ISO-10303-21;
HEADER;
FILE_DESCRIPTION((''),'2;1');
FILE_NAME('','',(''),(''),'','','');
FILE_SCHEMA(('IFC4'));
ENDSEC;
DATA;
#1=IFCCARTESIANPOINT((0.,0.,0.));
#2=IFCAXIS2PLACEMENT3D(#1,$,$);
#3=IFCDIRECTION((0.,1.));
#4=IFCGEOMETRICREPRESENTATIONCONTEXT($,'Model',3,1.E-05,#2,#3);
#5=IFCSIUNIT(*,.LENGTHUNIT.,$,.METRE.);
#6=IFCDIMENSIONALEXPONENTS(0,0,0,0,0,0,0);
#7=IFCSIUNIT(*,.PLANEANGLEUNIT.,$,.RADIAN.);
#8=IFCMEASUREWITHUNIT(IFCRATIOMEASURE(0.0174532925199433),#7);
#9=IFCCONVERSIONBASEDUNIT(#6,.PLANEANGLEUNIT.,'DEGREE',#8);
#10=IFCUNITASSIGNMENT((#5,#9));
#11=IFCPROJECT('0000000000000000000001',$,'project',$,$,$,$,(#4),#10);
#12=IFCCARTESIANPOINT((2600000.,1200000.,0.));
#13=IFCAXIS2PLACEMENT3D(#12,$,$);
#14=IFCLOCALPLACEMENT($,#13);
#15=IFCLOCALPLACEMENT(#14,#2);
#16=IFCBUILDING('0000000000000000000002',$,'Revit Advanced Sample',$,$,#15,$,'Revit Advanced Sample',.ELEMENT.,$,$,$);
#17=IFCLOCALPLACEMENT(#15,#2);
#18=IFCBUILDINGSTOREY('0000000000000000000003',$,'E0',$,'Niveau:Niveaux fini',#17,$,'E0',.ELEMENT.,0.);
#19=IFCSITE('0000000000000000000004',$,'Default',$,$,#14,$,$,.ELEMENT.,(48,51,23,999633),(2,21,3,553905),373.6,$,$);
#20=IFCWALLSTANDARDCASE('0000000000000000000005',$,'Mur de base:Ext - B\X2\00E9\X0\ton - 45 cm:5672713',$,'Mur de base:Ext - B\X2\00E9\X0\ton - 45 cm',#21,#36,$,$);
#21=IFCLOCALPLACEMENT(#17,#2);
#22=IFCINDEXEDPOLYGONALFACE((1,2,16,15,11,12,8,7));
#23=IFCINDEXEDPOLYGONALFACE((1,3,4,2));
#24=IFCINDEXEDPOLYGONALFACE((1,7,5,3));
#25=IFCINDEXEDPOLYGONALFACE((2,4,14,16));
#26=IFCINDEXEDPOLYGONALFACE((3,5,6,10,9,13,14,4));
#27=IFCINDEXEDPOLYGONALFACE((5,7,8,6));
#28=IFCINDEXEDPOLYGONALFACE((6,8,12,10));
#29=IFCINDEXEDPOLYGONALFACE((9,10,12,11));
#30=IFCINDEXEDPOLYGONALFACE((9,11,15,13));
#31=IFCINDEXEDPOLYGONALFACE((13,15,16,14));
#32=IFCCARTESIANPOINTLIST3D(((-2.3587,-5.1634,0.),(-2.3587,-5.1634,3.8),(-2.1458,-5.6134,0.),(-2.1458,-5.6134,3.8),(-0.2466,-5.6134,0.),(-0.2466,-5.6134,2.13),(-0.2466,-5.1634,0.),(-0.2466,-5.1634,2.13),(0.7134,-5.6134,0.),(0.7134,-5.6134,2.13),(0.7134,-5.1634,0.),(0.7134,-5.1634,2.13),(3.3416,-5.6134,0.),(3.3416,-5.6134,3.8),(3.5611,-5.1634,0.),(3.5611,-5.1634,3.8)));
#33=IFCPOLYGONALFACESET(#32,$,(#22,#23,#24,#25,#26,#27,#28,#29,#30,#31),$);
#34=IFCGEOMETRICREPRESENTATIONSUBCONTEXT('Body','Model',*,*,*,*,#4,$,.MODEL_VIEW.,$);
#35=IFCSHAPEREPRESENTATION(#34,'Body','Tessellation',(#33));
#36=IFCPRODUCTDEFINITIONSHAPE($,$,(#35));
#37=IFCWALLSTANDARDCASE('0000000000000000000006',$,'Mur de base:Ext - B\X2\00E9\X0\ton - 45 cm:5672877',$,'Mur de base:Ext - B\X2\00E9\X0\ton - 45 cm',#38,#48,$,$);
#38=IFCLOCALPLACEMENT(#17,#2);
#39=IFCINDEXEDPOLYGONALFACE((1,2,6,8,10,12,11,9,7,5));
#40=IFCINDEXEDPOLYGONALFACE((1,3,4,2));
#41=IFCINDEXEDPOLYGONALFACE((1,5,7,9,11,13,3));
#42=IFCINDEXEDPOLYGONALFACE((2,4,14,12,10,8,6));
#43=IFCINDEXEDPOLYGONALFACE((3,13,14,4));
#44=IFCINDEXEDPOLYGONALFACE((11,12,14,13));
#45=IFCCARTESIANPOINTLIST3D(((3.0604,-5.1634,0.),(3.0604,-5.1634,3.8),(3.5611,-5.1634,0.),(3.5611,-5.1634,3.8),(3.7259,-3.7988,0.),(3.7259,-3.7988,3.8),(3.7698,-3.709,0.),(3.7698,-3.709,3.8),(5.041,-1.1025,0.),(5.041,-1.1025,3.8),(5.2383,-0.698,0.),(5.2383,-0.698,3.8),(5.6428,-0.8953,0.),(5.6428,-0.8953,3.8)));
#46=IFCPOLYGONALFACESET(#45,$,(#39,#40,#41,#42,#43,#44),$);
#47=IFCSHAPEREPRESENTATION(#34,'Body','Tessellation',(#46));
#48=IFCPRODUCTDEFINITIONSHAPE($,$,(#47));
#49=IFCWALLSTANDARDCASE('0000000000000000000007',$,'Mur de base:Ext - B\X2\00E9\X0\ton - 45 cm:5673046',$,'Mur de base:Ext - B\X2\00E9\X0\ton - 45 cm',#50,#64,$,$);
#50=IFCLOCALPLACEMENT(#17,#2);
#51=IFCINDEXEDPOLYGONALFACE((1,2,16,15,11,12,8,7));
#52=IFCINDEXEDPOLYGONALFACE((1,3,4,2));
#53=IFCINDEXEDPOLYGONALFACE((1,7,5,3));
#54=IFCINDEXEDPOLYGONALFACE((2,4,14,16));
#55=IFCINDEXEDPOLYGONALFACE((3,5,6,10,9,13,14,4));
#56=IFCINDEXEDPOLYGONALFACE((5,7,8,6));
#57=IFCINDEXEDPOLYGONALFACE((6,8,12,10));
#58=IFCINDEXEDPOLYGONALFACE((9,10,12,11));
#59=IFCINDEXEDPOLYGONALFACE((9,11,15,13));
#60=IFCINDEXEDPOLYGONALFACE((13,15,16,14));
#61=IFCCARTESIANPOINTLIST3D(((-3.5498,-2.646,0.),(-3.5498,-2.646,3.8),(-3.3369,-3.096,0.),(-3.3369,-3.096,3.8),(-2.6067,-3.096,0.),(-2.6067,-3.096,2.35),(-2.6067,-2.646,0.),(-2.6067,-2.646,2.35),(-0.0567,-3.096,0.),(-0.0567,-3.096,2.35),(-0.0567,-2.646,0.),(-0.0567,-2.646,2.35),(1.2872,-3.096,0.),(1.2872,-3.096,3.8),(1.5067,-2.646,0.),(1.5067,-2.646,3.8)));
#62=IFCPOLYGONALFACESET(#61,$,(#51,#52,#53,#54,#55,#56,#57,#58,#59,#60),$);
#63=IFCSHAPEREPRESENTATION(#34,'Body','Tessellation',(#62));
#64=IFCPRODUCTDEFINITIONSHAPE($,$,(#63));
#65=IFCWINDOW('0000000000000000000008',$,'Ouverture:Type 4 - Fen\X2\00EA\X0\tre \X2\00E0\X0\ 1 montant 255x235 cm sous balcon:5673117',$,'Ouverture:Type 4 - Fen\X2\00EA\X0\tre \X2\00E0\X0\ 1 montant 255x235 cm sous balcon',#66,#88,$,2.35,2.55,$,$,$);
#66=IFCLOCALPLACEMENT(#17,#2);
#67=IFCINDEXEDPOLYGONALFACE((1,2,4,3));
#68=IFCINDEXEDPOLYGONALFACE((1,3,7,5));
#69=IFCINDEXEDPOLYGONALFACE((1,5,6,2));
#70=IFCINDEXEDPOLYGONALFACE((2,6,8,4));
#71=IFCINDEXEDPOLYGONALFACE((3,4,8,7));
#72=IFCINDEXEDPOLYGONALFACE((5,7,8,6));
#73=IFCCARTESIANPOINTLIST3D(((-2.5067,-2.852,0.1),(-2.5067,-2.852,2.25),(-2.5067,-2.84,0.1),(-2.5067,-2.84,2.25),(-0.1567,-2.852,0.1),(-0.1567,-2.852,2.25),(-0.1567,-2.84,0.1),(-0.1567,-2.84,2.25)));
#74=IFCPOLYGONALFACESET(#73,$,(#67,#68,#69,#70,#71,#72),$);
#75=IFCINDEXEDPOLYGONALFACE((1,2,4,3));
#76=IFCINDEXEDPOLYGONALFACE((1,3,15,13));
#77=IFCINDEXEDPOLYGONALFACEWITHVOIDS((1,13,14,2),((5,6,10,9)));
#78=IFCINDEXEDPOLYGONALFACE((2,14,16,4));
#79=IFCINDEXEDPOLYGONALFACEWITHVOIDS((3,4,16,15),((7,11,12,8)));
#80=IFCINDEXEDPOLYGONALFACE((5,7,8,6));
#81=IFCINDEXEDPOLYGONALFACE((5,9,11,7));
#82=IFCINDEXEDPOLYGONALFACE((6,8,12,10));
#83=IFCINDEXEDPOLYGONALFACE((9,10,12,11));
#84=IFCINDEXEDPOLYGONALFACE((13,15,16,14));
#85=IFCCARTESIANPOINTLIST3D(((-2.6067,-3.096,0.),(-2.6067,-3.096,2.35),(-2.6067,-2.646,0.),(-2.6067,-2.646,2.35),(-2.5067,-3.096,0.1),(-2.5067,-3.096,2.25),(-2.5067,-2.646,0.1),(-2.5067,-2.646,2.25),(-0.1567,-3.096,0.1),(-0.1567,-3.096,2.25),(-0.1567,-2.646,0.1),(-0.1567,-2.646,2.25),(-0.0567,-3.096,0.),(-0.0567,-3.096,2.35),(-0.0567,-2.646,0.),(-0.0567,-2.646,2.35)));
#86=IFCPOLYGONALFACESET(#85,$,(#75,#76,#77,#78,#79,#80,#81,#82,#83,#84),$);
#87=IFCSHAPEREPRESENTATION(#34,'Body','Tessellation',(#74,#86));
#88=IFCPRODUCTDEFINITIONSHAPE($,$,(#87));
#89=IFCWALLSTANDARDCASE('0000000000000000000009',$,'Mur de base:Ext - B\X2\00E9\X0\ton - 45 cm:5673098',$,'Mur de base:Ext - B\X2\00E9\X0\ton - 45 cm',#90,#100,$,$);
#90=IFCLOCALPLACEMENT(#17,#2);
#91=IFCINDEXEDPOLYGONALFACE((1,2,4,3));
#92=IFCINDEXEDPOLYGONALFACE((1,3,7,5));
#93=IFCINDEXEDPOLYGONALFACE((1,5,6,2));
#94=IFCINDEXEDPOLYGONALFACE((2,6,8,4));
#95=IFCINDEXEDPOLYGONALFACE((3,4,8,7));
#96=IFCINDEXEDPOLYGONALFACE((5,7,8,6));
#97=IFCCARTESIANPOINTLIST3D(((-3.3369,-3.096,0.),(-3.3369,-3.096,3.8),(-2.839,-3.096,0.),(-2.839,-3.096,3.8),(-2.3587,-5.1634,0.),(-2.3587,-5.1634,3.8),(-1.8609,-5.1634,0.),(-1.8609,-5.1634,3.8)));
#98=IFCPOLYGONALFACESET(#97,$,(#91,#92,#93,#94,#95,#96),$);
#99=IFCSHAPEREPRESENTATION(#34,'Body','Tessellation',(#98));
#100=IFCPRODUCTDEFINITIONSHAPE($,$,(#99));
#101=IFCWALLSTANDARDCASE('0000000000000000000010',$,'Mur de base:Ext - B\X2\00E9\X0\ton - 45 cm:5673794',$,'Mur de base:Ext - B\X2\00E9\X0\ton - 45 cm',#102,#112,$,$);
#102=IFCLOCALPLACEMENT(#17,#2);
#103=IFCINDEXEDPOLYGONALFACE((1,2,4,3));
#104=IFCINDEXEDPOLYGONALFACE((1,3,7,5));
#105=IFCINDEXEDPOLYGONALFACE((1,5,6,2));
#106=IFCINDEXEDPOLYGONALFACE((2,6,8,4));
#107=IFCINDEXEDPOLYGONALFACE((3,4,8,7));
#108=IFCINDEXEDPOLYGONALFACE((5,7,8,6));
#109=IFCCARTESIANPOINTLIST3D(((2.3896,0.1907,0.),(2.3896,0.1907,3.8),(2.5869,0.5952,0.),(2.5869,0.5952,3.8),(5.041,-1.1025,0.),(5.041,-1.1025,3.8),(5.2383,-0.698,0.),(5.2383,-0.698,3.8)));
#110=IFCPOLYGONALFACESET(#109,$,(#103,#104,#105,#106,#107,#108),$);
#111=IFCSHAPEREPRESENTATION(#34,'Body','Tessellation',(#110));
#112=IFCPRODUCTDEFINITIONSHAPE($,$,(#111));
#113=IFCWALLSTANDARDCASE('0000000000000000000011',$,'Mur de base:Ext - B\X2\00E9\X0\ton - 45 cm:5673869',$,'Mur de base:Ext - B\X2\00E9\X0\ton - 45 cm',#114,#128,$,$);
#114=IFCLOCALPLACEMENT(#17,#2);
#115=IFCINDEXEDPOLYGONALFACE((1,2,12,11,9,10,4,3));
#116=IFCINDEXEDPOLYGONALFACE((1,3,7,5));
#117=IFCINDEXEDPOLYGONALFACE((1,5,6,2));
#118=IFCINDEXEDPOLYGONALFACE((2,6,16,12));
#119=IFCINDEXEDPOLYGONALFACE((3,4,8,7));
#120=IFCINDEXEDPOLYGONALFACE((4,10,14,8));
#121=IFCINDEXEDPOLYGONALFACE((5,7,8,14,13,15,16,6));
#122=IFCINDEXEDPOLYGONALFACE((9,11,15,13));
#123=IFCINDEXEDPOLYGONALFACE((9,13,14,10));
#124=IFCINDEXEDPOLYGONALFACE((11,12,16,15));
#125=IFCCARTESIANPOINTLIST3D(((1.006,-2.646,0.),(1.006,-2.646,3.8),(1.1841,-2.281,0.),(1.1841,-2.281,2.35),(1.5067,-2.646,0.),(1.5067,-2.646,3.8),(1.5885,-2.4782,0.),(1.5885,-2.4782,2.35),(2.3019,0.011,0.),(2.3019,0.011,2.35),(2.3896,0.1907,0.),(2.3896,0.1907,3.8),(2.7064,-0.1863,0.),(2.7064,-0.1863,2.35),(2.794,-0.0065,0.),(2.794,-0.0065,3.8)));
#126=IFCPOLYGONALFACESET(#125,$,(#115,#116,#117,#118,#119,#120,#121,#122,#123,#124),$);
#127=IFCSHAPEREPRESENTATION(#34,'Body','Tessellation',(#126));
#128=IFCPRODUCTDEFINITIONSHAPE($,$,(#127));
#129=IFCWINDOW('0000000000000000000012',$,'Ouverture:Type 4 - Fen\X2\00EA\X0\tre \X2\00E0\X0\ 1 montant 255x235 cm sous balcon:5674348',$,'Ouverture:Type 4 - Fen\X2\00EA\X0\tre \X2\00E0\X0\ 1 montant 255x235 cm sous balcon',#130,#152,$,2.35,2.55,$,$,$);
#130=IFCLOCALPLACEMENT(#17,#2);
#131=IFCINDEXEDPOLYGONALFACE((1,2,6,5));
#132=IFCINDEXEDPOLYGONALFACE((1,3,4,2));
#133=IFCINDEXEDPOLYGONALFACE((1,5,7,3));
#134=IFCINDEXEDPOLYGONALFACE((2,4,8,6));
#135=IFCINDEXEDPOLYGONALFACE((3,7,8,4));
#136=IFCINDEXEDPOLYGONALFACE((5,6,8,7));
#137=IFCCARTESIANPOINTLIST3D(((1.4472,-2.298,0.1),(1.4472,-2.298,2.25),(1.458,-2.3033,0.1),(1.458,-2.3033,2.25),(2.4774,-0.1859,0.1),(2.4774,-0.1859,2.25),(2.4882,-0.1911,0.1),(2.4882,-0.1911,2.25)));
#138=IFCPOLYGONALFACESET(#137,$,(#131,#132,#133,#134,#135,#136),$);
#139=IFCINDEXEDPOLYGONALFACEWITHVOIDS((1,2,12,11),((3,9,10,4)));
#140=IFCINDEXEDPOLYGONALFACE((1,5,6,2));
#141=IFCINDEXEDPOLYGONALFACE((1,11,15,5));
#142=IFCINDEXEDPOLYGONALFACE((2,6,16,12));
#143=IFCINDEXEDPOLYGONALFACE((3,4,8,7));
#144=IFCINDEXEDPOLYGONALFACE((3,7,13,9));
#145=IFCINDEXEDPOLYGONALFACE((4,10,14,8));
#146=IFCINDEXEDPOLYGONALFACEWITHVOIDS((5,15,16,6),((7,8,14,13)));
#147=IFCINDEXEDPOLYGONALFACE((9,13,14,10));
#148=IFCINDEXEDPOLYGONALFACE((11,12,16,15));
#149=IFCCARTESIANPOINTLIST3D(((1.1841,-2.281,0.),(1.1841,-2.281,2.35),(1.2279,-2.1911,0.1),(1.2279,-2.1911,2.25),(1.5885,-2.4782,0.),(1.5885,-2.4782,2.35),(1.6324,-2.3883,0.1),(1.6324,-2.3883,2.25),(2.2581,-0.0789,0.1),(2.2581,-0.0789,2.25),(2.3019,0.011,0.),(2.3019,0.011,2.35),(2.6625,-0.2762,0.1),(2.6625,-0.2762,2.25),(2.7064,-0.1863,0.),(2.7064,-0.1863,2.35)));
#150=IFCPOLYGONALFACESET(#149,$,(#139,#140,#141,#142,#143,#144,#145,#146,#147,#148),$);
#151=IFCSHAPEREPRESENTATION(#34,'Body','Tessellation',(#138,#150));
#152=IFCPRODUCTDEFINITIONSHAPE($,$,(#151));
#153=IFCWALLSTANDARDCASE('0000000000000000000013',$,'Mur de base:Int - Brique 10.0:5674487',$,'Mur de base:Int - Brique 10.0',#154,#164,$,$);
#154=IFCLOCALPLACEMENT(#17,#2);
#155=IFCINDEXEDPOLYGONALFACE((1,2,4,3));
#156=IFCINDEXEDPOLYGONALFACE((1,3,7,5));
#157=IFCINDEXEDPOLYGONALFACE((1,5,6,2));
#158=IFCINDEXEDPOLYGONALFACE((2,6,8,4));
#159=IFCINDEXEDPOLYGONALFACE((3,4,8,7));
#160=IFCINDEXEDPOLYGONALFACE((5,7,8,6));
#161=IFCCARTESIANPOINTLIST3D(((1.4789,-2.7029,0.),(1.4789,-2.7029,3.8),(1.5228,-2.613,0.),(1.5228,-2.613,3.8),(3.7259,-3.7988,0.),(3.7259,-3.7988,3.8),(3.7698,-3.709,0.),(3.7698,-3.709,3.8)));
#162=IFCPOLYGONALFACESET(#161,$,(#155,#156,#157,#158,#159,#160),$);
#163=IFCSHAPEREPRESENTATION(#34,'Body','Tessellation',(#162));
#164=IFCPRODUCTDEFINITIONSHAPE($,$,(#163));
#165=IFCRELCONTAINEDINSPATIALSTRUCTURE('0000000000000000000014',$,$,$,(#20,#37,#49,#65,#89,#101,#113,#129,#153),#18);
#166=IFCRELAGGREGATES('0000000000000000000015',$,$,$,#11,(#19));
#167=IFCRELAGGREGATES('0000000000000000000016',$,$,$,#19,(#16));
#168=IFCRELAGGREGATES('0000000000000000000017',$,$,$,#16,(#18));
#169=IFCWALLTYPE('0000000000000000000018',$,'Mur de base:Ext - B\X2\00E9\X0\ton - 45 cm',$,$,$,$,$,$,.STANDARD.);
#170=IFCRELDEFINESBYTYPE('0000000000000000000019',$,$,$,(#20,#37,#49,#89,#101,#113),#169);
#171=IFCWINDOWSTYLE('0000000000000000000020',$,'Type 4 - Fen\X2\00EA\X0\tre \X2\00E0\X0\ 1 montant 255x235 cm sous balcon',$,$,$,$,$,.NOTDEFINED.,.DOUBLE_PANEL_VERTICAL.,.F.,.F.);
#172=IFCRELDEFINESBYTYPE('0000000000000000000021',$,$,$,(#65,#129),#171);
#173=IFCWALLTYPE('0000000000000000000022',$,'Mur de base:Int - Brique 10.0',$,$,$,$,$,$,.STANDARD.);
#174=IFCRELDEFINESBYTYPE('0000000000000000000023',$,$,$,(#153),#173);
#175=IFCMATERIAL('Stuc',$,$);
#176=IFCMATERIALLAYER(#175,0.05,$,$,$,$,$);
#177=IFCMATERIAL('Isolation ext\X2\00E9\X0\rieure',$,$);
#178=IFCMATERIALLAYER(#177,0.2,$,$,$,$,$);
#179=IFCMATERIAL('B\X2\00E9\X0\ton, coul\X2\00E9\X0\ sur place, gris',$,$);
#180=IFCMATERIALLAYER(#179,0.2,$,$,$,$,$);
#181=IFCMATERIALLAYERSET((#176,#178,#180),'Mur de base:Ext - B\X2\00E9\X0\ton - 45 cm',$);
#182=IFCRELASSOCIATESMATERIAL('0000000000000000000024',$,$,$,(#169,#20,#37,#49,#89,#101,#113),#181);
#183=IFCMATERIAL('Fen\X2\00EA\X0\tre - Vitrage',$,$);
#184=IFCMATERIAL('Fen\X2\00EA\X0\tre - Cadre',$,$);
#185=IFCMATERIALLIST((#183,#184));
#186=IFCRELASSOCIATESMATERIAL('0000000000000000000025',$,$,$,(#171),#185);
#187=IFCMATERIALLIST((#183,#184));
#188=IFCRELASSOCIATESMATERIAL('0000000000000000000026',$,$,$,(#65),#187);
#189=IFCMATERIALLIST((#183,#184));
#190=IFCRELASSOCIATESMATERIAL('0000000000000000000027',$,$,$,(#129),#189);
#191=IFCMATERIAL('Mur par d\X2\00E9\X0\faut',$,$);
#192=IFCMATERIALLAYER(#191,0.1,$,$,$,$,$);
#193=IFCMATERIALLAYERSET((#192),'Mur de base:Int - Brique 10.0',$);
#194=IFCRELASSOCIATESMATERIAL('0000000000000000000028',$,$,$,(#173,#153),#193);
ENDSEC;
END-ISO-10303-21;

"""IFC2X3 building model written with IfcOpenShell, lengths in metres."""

from ifc_helpers import new_model, entity, si_unit, converted_unit, direction, frame, frame_2d, origin, place, context, subcontext, project, spatial, polyline, rectangle, outline, extrude, source, transform, mapped, material, material_list, layer, layer_set, layer_usage, type_object, type_shapes, element, fill, save


model = new_model("IFC2X3")

# Units and contexts
model_context = context("Model", 3, precision=1e-05, world=origin(), true_north=direction((0.0, 1.0)))
body_context = subcontext(model_context, "Body", "Model", "MODEL_VIEW")
ifc_project = project(units=[si_unit("LENGTHUNIT", "METRE"), converted_unit("PLANEANGLEUNIT", "DEGREE", entity("IfcRatioMeasure", 0.0174532925199433), si_unit("PLANEANGLEUNIT", "RADIAN"), dimensions=[0, 0, 0, 0, 0, 0, 0])], contexts=[model_context])

# Site, building, storey
site_placement = place(None, frame((2600000.0, 1200000.0, 0.0)))
site = spatial("IfcSite", under=ifc_project, at=site_placement, Name="Default", CompositionType="ELEMENT", RefLatitude=(48, 51, 23, 999633), RefLongitude=(2, 21, 3, 553905), RefElevation=373.6)
building_placement = place(site_placement, origin())
building = spatial("IfcBuilding", under=site, at=building_placement, Name="Revit Advanced Sample", LongName="Revit Advanced Sample", CompositionType="ELEMENT")
storey_placement = place(building_placement, origin())
storey = spatial("IfcBuildingStorey", under=building, at=storey_placement, Name="E0", ObjectType="Niveau:Niveaux fini", LongName="E0", CompositionType="ELEMENT", Elevation=0.0)

# Wall, opening
ifc_material_1 = material(Name="Stuc")
ifc_layer_1 = layer(ifc_material_1, 0.05)
ifc_material_2 = material(Name="Isolation extérieure")
ifc_layer_2 = layer(ifc_material_2, 0.2)
ifc_material_3 = material(Name="Béton, coulé sur place, gris")
ifc_layer_3 = layer(ifc_material_3, 0.2)
ifc_layer_set_1 = layer_set([ifc_layer_1, ifc_layer_2, ifc_layer_3], Name="Mur de base:Ext - Béton - 45 cm")
ifc_layer_usage_1 = layer_usage(ifc_layer_set_1, "AXIS2", "POSITIVE", -0.225)
wall_type_1 = type_object("IfcWallType", Name="Mur de base:Ext - Béton - 45 cm", PredefinedType="STANDARD", material=ifc_layer_set_1)
wall_1_placement = place(storey_placement, frame((-2.3587, -5.3884, 0.0)))
wall_1 = element("IfcWallStandardCase", 1, at=wall_1_placement, inside=storey, type_object=wall_type_1, material=ifc_layer_usage_1, Name="Mur de base:Ext - Béton - 45 cm:5672713", ObjectType="Mur de base:Ext - Béton - 45 cm", context=body_context, shape_type="SweptSolid", body=[
    extrude(outline(polyline([(0.2129, -0.225), (5.7003, -0.225), (5.9198, 0.225), (5.4191, 0.225), (0.4978, 0.225), (0.0, 0.225), (0.2129, -0.225)])), origin(), (0.0, 0.0, 1.0), 3.8),
])
opening_1_placement = place(wall_1_placement, frame((3.0721, 0.225, 0.0)))
element("IfcOpeningElement", 2, at=opening_1_placement, cuts=wall_1, ObjectType="Opening", context=body_context, shape_type="SweptSolid", body=[
    extrude(rectangle(XDim=2.13, YDim=0.96, at=frame_2d((1.065, 0.48), x_axis=(1.0, 0.0))), frame((0.0, 0.0, 0.0), z_axis=(0.0, -1.0, 0.0), x_axis=(0.0, 0.0, 1.0)), (0.0, 0.0, 1.0), 0.45),
])

# Wall
ifc_layer_usage_2 = layer_usage(ifc_layer_set_1, "AXIS2", "POSITIVE", -0.225)
wall_2_placement = place(storey_placement, frame((3.2626, -5.262, 0.0), z_axis=(0.0, 0.0, 1.0), x_axis=(0.438371, 0.898794, 0.0)))
element("IfcWallStandardCase", 3, at=wall_2_placement, inside=storey, type_object=wall_type_1, material=ifc_layer_usage_2, Name="Mur de base:Ext - Béton - 45 cm:5672877", ObjectType="Mur de base:Ext - Béton - 45 cm", context=body_context, shape_type="SweptSolid", body=[
    extrude(outline(polyline([(4.9682, -0.225), (4.9682, 0.225), (4.5182, 0.225), (1.6182, 0.225), (1.5182, 0.225), (0.0, 0.225), (0.2195, -0.225), (4.9682, -0.225)])), origin(), (0.0, 0.0, 1.0), 3.8),
])

# Wall, opening, window
ifc_layer_usage_3 = layer_usage(ifc_layer_set_1, "AXIS2", "POSITIVE", -0.225)
wall_3_placement = place(storey_placement, frame((1.5067, -2.871, 0.0), z_axis=(0.0, 0.0, 1.0), x_axis=(-1.0, 0.0, 0.0)))
wall_3 = element("IfcWallStandardCase", 4, at=wall_3_placement, inside=storey, type_object=wall_type_1, material=ifc_layer_usage_3, Name="Mur de base:Ext - Béton - 45 cm:5673046", ObjectType="Mur de base:Ext - Béton - 45 cm", context=body_context, shape_type="SweptSolid", body=[
    extrude(outline(polyline([(0.0, -0.225), (0.5007, -0.225), (5.0565, -0.225), (4.8435, 0.225), (4.3457, 0.225), (0.2195, 0.225), (0.0, -0.225)])), origin(), (0.0, 0.0, 1.0), 3.8),
])
opening_2_placement = place(wall_3_placement, frame((4.1133, 0.225, 0.0)))
opening_2 = element("IfcOpeningElement", 5, at=opening_2_placement, cuts=wall_3, ObjectType="Opening", context=body_context, shape_type="SweptSolid", body=[
    extrude(rectangle(XDim=2.35, YDim=2.55, at=frame_2d((1.175, 1.275), x_axis=(-1.0, 0.0))), frame((0.0, 0.0, 0.0), z_axis=(0.0, -1.0, 0.0), x_axis=(0.0, 0.0, 1.0)), (0.0, 0.0, 1.0), 0.45),
])
ifc_material_4 = material(Name="Fenêtre - Vitrage")
ifc_material_5 = material(Name="Fenêtre - Cadre")
ifc_material_list_1 = material_list([ifc_material_4, ifc_material_5])
ifc_material_list_2 = material_list([ifc_material_4, ifc_material_5])
window_style = type_object("IfcWindowStyle", Name="Type 4 - Fenêtre à 1 montant 255x235 cm sous balcon", ConstructionType="NOTDEFINED", OperationType="DOUBLE_PANEL_VERTICAL", ParameterTakesPrecedence=False, Sizeable=False, material=ifc_material_list_2)
shared_shape = source(origin(), body_context, "Body", "SweptSolid", [
    extrude(rectangle(XDim=0.012, YDim=2.35, at=frame_2d((0.0, 0.0), x_axis=(1.0, 0.0))), frame((1.275, 0.2, 0.1), z_axis=(0.0, 0.0, 1.0), x_axis=(0.0, -1.0, 0.0)), (0.0, 0.0, 1.0), 2.15),
    extrude(outline(polyline([(-1.275, -1.175), (1.275, -1.175), (1.275, 1.175), (-1.275, 1.175), (-1.275, -1.175)]), holes=[polyline([(-1.175, -1.075), (-1.175, 1.075), (1.175, 1.075), (1.175, -1.075), (-1.175, -1.075)])]), frame((1.275, 0.0, 1.175), z_axis=(0.0, 1.0, 0.0), x_axis=(1.0, 0.0, 0.0)), (0.0, 0.0, 1.0), 0.45),
])
type_shapes(window_style, [shared_shape])
window_1_placement = place(opening_2_placement, frame((-2.55, -0.45, 0.0)))
window_1 = element("IfcWindow", 6, at=window_1_placement, inside=storey, type_object=window_style, material=ifc_material_list_1, Name="Ouverture:Type 4 - Fenêtre à 1 montant 255x235 cm sous balcon:5673117", ObjectType="Ouverture:Type 4 - Fenêtre à 1 montant 255x235 cm sous balcon", OverallHeight=2.35, OverallWidth=2.55, context=body_context, shape_type="MappedRepresentation", body=[
    mapped(shared_shape, transform((0.0, 0.0, 0.0), scale=1.0)),
])
fill(opening_2, window_1)

# Walls
ifc_layer_usage_4 = layer_usage(ifc_layer_set_1, "AXIS2", "POSITIVE", -0.225)
wall_4_placement = place(storey_placement, frame((-3.1335, -2.9998, 0.0), z_axis=(0.0, 0.0, 1.0), x_axis=(0.427693, -0.903924, 0.0)))
element("IfcWallStandardCase", 7, at=wall_4_placement, inside=storey, type_object=wall_type_1, material=ifc_layer_usage_4, Name="Mur de base:Ext - Béton - 45 cm:5673098", ObjectType="Mur de base:Ext - Béton - 45 cm", context=body_context, shape_type="SweptSolid", body=[
    extrude(outline(polyline([(2.2871, -0.225), (2.5, 0.225), (0.2129, 0.225), (0.0, -0.225), (2.2871, -0.225)])), origin(), (0.0, 0.0, 1.0), 3.8),
])
ifc_layer_usage_5 = layer_usage(ifc_layer_set_1, "AXIS2", "POSITIVE", -0.225)
wall_5_placement = place(storey_placement, frame((5.1397, -0.9002, 0.0), z_axis=(0.0, 0.0, 1.0), x_axis=(-0.898794, 0.438371, 0.0)))
element("IfcWallStandardCase", 8, at=wall_5_placement, inside=storey, type_object=wall_type_1, material=ifc_layer_usage_5, Name="Mur de base:Ext - Béton - 45 cm:5673794", ObjectType="Mur de base:Ext - Béton - 45 cm", context=body_context, shape_type="SweptSolid", body=[
    extrude(rectangle(XDim=2.95, YDim=0.45, at=frame_2d((1.475, 0.0), x_axis=(-1.0, 0.0))), origin(), (0.0, 0.0, 1.0), 3.8),
])

# Wall, opening, window
ifc_layer_usage_6 = layer_usage(ifc_layer_set_1, "AXIS2", "POSITIVE", -0.225)
wall_6_placement = place(storey_placement, frame((2.5918, 0.0921, 0.0), z_axis=(0.0, 0.0, 1.0), x_axis=(-0.438371, -0.898794, 0.0)))
wall_6 = element("IfcWallStandardCase", 9, at=wall_6_placement, inside=storey, type_object=wall_type_1, material=ifc_layer_usage_6, Name="Mur de base:Ext - Béton - 45 cm:5673869", ObjectType="Mur de base:Ext - Béton - 45 cm", context=body_context, shape_type="SweptSolid", body=[
    extrude(outline(polyline([(0.0, -0.225), (3.1562, -0.225), (2.9367, 0.225), (2.9, 0.225), (0.0, 0.225), (0.0, -0.225)])), origin(), (0.0, 0.0, 1.0), 3.8),
])
opening_3_placement = place(wall_6_placement, frame((0.2, -0.225, 0.0)))
opening_3 = element("IfcOpeningElement", 10, at=opening_3_placement, cuts=wall_6, ObjectType="Opening", context=body_context, shape_type="SweptSolid", body=[
    extrude(rectangle(XDim=2.35, YDim=2.55, at=frame_2d((1.175, 1.275), x_axis=(-1.0, 0.0))), frame((0.0, 0.0, 0.0), z_axis=(0.0, 1.0, 0.0), x_axis=(0.0, 0.0, 1.0)), (0.0, 0.0, 1.0), 0.45),
])
ifc_material_list_3 = material_list([ifc_material_4, ifc_material_5])
window_2_placement = place(opening_3_placement, frame((2.55, 0.45, 0.0), z_axis=(0.0, 0.0, 1.0), x_axis=(-1.0, 0.0, 0.0)))
window_2 = element("IfcWindow", 11, at=window_2_placement, inside=storey, type_object=window_style, material=ifc_material_list_3, Name="Ouverture:Type 4 - Fenêtre à 1 montant 255x235 cm sous balcon:5674348", ObjectType="Ouverture:Type 4 - Fenêtre à 1 montant 255x235 cm sous balcon", OverallHeight=2.35, OverallWidth=2.55, context=body_context, shape_type="MappedRepresentation", body=[
    mapped(shared_shape, transform((0.0, 0.0, 0.0), scale=1.0)),
])
fill(opening_3, window_2)

# Wall
ifc_material_6 = material(Name="Mur par défaut")
ifc_layer_4 = layer(ifc_material_6, 0.1)
ifc_layer_set_2 = layer_set([ifc_layer_4], Name="Mur de base:Int - Brique 10.0")
ifc_layer_usage_7 = layer_usage(ifc_layer_set_2, "AXIS2", "NEGATIVE", 0.05)
wall_type_2 = type_object("IfcWallType", Name="Mur de base:Int - Brique 10.0", PredefinedType="STANDARD", material=ifc_layer_set_2)
wall_7_placement = place(storey_placement, frame((1.5008, -2.658, 0.0), z_axis=(0.0, 0.0, 1.0), x_axis=(0.898794, -0.438371, 0.0)))
element("IfcWallStandardCase", 12, at=wall_7_placement, inside=storey, type_object=wall_type_2, material=ifc_layer_usage_7, Name="Mur de base:Int - Brique 10.0:5674487", ObjectType="Mur de base:Int - Brique 10.0", context=body_context, shape_type="SweptSolid", body=[
    extrude(rectangle(XDim=2.5, YDim=0.1, at=frame_2d((1.25, 0.0), x_axis=(-1.0, 0.0))), origin(), (0.0, 0.0, 1.0), 3.8),
])

save(model, "model.ifc")
